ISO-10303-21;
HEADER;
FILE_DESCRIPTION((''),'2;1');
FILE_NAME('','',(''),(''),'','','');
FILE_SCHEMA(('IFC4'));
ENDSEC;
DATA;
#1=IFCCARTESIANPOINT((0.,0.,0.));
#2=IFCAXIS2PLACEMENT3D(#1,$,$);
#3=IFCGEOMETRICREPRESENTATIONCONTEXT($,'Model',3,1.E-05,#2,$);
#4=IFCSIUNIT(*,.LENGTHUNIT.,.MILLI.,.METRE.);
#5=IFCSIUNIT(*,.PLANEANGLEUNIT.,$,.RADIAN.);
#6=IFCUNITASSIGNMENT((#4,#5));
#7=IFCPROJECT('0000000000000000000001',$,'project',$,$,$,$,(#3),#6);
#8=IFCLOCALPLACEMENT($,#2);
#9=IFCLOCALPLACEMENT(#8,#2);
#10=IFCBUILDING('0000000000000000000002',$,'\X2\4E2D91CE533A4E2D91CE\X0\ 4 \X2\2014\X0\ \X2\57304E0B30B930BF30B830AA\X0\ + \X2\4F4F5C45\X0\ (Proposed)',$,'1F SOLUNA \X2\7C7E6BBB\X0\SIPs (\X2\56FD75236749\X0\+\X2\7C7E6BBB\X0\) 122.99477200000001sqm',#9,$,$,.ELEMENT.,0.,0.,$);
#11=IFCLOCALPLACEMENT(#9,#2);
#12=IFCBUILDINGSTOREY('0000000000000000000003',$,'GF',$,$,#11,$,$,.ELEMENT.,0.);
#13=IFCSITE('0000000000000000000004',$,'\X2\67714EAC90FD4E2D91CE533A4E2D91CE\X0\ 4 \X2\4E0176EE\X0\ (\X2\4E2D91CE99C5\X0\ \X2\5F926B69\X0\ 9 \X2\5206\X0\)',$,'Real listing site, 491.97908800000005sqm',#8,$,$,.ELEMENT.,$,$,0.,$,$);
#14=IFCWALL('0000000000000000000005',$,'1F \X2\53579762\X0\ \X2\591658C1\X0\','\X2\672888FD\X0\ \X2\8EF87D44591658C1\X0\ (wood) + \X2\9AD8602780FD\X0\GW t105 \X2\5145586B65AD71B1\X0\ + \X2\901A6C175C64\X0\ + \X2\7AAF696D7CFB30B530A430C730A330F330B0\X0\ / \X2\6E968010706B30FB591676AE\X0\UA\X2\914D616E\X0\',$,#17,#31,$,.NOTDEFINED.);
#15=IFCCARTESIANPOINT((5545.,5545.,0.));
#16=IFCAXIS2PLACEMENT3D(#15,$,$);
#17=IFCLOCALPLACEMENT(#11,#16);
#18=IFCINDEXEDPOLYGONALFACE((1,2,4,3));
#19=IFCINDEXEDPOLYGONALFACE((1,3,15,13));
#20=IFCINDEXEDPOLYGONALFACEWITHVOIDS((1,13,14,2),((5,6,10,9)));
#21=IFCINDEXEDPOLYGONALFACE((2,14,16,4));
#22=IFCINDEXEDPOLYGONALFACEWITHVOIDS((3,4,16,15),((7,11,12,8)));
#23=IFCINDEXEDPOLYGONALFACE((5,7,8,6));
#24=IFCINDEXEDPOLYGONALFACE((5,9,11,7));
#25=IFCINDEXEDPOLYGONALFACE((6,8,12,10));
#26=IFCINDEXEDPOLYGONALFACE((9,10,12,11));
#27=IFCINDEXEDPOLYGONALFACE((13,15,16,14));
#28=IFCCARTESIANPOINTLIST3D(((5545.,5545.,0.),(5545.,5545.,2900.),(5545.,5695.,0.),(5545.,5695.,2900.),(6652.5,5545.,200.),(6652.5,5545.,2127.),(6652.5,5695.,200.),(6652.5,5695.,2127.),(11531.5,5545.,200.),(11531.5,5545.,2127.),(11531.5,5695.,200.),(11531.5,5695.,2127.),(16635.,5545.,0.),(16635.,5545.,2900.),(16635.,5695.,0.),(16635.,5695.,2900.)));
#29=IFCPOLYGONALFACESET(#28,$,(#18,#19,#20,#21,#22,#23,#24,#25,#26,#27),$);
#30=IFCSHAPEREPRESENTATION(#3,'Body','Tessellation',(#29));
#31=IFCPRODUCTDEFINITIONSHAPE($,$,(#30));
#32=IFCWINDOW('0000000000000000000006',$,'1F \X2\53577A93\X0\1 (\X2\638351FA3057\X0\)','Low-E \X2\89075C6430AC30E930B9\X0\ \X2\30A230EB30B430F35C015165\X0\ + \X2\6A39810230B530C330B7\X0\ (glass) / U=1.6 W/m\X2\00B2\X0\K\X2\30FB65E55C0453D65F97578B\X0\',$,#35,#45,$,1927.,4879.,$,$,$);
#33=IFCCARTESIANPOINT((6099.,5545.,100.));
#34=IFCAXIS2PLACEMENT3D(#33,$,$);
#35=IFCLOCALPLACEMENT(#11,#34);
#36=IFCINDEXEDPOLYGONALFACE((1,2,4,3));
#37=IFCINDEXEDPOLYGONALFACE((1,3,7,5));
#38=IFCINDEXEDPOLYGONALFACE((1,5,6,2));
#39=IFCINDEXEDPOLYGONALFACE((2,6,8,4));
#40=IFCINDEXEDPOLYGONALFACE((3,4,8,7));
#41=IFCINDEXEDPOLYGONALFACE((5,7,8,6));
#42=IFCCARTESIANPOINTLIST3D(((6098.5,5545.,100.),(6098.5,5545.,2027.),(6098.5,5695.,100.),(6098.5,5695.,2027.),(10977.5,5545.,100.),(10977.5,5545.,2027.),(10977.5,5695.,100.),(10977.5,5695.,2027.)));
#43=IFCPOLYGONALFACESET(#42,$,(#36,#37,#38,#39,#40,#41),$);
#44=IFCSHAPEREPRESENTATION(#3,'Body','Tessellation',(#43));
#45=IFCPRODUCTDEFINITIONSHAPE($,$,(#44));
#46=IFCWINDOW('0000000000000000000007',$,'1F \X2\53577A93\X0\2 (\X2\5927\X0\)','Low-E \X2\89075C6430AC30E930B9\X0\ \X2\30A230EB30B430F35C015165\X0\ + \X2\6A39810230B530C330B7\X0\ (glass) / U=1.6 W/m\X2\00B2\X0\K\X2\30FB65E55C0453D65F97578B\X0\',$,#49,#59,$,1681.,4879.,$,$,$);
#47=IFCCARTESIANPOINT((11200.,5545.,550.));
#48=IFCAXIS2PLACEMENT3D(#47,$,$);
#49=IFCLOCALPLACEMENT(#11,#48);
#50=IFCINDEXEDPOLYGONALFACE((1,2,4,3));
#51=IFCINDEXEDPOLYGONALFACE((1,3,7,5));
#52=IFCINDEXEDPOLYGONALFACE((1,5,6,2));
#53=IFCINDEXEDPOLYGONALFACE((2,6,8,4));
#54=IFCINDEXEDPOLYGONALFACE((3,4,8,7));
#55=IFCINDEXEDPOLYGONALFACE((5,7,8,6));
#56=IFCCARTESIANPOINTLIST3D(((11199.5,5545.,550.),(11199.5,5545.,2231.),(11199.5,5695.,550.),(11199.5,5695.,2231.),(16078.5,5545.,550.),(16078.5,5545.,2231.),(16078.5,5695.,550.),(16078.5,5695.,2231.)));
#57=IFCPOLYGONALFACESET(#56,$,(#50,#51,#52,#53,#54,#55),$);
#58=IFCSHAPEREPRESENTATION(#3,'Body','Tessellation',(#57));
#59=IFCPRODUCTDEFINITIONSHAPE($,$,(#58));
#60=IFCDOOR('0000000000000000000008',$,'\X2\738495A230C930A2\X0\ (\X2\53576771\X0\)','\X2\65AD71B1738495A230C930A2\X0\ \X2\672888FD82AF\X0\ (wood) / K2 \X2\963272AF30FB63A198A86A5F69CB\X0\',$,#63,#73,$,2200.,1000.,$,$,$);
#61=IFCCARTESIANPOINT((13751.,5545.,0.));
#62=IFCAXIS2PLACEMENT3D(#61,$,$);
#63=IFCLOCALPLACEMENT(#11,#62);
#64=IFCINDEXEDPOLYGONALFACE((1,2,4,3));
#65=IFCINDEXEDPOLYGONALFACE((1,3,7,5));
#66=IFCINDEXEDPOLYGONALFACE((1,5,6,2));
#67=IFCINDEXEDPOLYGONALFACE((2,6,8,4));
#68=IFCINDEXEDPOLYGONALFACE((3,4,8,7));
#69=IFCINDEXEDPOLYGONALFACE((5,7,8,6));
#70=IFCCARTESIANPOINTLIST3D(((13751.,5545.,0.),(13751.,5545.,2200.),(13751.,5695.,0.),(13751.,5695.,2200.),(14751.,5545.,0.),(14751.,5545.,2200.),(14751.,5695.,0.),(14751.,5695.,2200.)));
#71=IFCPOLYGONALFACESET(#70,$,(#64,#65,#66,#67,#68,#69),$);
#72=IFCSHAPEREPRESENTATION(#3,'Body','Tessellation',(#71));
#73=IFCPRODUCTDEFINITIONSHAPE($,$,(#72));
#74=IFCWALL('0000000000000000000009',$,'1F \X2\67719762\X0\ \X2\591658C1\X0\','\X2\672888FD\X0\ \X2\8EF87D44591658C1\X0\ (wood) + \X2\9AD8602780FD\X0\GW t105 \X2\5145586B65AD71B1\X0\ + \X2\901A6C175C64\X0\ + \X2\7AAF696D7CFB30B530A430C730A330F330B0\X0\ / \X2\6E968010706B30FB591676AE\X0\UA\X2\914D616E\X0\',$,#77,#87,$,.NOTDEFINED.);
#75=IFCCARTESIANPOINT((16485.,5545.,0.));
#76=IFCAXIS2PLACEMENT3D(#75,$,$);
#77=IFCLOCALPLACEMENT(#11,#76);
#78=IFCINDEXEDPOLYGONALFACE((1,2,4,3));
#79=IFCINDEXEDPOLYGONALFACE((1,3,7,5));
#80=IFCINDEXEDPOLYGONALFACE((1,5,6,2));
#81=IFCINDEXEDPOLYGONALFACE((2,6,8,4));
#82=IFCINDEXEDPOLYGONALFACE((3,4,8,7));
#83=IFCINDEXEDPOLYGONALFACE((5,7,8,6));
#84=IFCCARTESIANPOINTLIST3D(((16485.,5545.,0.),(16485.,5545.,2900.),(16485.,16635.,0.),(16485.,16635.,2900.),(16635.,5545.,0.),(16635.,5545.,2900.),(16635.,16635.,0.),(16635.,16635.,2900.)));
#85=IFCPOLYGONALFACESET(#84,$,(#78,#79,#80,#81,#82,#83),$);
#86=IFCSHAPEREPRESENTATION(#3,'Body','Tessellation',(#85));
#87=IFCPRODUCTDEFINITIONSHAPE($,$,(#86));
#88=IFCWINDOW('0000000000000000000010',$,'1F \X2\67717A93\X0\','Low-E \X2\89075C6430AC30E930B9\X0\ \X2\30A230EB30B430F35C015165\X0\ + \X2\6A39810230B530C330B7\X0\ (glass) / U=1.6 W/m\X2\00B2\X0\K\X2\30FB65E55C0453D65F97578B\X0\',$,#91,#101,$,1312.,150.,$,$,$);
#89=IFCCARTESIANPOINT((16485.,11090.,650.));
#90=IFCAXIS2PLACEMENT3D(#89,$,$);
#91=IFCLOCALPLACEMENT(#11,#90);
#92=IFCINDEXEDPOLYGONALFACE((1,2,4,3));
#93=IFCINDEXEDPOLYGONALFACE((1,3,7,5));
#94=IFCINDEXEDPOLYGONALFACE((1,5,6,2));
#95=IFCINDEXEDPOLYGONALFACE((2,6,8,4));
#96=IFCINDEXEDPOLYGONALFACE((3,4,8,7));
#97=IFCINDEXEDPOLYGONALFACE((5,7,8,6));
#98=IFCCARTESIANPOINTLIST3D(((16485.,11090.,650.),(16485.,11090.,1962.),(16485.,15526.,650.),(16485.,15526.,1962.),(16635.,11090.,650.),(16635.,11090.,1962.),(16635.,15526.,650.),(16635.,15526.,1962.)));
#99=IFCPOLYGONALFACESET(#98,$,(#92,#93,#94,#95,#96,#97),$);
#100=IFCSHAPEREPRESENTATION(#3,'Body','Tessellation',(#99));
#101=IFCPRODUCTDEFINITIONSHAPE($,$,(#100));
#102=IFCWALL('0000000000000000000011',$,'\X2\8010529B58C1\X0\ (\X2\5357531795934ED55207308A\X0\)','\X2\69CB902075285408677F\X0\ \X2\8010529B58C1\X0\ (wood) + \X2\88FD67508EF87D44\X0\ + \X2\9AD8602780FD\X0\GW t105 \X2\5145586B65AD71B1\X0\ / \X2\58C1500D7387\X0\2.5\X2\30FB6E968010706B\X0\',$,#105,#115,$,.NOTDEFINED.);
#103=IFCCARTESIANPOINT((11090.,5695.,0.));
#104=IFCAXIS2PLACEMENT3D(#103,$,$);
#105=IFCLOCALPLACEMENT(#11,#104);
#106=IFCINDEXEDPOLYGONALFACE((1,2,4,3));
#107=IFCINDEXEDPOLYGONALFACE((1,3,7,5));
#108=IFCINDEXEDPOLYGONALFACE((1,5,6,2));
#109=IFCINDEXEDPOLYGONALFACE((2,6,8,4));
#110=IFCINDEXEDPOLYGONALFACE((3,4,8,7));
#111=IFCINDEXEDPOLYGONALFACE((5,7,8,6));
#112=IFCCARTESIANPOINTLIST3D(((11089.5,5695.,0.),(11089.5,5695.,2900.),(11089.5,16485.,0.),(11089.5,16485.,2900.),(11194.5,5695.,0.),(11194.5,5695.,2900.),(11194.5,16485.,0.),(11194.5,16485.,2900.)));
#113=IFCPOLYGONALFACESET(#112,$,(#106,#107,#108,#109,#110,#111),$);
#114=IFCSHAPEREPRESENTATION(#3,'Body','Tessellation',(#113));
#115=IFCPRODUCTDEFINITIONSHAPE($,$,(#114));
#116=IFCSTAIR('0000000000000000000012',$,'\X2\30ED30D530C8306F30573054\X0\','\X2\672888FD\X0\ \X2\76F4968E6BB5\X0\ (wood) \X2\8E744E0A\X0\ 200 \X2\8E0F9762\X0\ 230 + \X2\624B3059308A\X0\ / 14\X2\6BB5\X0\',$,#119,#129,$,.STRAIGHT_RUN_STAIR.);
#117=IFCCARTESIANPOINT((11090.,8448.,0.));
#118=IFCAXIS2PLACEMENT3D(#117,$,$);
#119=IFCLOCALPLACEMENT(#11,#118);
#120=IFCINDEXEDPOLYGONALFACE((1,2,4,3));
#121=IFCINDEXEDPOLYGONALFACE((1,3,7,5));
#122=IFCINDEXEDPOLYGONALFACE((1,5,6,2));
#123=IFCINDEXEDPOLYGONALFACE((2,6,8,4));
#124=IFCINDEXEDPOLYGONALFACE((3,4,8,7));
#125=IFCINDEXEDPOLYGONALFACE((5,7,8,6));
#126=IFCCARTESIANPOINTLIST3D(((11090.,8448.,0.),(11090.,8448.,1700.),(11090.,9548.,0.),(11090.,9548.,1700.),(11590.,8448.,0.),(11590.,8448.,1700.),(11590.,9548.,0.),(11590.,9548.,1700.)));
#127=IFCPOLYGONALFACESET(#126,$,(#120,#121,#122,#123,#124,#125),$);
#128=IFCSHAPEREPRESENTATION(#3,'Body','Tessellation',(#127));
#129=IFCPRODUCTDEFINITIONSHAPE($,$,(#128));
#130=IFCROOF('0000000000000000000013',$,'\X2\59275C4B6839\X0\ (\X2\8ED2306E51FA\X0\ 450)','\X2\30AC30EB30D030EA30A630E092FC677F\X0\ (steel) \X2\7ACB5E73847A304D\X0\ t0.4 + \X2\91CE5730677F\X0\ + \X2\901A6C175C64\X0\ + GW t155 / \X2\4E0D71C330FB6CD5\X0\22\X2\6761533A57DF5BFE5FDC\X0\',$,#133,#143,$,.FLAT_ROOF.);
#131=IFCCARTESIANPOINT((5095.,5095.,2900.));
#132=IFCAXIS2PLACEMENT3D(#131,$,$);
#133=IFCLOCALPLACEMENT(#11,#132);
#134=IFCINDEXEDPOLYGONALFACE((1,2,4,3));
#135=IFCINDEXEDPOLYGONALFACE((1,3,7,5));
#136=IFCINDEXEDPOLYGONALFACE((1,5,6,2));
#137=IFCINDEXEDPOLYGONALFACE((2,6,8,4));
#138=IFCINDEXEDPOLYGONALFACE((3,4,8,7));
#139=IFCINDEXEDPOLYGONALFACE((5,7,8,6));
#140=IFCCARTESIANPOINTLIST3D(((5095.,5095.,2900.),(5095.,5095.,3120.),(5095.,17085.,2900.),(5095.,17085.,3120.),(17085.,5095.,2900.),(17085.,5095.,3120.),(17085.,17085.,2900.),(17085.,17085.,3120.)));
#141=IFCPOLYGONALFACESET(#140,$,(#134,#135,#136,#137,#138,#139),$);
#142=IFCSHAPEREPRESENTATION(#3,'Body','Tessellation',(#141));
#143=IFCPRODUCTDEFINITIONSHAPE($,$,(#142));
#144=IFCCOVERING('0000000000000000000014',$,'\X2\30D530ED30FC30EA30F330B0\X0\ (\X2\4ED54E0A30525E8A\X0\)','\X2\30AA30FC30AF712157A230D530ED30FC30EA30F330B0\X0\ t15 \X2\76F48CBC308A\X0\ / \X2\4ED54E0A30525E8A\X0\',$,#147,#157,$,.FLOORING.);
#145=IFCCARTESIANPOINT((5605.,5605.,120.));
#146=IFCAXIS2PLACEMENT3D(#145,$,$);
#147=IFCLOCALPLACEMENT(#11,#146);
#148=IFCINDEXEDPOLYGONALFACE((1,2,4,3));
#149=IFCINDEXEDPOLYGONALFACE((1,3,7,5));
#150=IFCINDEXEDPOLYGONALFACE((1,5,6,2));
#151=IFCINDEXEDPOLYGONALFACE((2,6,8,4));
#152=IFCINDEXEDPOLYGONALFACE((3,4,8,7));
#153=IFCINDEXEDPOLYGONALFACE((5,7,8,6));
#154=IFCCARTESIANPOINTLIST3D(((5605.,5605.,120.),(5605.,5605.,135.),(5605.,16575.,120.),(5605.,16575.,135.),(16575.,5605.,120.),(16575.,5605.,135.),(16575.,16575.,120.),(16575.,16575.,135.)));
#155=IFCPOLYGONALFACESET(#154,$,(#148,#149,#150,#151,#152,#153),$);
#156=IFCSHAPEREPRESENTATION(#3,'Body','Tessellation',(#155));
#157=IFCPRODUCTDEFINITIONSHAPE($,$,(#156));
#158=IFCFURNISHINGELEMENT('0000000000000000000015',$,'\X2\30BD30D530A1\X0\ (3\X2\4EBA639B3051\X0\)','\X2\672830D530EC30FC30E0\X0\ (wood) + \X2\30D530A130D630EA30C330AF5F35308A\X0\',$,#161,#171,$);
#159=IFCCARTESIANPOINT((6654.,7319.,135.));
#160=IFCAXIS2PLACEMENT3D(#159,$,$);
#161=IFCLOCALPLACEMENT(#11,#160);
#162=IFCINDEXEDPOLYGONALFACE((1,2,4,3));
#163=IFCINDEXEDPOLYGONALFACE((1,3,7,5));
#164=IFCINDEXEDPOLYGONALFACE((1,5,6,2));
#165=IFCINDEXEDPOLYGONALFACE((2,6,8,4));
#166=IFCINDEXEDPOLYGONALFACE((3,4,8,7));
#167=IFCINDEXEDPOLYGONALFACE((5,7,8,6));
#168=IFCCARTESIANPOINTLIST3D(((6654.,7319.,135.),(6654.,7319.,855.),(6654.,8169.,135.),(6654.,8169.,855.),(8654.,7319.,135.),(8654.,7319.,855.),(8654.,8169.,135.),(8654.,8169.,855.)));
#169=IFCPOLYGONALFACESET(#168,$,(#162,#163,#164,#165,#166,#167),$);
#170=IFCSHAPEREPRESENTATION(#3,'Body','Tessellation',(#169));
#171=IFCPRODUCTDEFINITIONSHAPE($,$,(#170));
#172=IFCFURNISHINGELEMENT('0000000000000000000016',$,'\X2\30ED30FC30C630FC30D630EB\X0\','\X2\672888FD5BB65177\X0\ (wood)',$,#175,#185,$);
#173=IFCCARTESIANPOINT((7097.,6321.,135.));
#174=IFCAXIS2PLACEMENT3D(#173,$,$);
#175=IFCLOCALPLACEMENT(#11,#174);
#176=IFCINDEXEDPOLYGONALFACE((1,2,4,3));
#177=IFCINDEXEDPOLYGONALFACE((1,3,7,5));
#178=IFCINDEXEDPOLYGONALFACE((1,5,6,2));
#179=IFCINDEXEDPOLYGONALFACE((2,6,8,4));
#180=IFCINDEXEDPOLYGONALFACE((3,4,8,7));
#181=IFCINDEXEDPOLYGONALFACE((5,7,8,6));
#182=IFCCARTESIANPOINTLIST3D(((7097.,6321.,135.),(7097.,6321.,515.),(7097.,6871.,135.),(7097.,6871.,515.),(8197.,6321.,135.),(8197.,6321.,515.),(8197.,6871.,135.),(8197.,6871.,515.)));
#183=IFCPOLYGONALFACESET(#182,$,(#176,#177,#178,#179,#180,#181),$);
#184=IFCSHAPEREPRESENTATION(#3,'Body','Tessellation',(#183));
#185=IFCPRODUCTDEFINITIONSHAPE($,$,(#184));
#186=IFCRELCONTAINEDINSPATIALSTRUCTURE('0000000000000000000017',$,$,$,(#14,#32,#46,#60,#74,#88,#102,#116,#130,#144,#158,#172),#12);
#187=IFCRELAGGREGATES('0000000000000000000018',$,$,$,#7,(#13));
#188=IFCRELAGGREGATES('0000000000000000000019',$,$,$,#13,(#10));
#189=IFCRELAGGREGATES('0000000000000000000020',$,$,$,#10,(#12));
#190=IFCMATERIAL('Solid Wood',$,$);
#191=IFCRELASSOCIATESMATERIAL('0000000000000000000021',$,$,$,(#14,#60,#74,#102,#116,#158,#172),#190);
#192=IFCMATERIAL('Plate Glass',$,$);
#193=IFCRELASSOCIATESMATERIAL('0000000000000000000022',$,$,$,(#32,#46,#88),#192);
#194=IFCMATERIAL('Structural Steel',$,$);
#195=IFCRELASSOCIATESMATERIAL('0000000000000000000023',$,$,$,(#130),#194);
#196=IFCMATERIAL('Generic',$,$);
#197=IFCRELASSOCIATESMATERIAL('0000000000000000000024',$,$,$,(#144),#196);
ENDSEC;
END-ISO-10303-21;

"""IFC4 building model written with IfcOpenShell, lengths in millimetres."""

from ifc_helpers import new_model, si_unit, frame, frame_2d, origin, place, context, project, spatial, rectangle, extrude, material, element, fill, save


model = new_model("IFC4")

# Units and contexts
model_context = context("Model", 3, precision=1e-05, world=origin())
ifc_project = project(units=[si_unit("LENGTHUNIT", "METRE", prefix="MILLI"), si_unit("PLANEANGLEUNIT", "RADIAN")], contexts=[model_context])

# Site, building, storey
site_placement = place(None, origin())
site = spatial("IfcSite", under=ifc_project, at=site_placement, Name="東京都中野区中野 4 丁目 (中野駅 徒歩 9 分)", ObjectType="Real listing site, 491.97908800000005sqm", CompositionType="ELEMENT", RefElevation=0.0)
building_placement = place(site_placement, origin())
building = spatial("IfcBuilding", under=site, at=building_placement, Name="中野区中野 4 — 地下スタジオ + 住居 (Proposed)", ObjectType="1F SOLUNA 籾殻SIPs (国産杉+籾殻) 122.99477200000001sqm", CompositionType="ELEMENT", ElevationOfRefHeight=0.0, ElevationOfTerrain=0.0)
storey_placement = place(building_placement, origin())
storey = spatial("IfcBuildingStorey", under=building, at=storey_placement, Name="GF", CompositionType="ELEMENT", Elevation=0.0)

# Shared definitions
ifc_material_1 = material(Name="Solid Wood")

# Wall, openings, windows, door
wall_1_placement = place(storey_placement, frame((5545.0, 5545.0, 0.0)))
wall_1 = element("IfcWall", 1, at=wall_1_placement, inside=storey, material=ifc_material_1, Name="1F 南面 外壁", Description="木製 軸組外壁 (wood) + 高性能GW t105 充填断熱 + 通気層 + 窯業系サイディング / 準耐火・外皮UA配慮", PredefinedType="NOTDEFINED", context=model_context, shape_type="SweptSolid", body=[
    extrude(rectangle(XDim=11090.0, YDim=150.0, at=frame_2d((5545.0, 75.0))), frame((5545.0, 5545.0, 0.0)), (0.0, 0.0, 1.0), 2900.0),
])
opening_1_placement = place(storey_placement, frame((6099.0, 5545.0, 100.0)))
opening_1 = element("IfcOpeningElement", 2, at=opening_1_placement, cuts=wall_1, PredefinedType="NOTDEFINED", context=model_context, shape_type="SweptSolid", body=[
    extrude(rectangle(XDim=4879.0, YDim=150.0, at=frame_2d((2439.0, 75.0))), frame((6099.0, 5545.0, 100.0)), (0.0, 0.0, 1.0), 1927.0),
])
opening_2_placement = place(storey_placement, frame((11200.0, 5545.0, 550.0)))
opening_2 = element("IfcOpeningElement", 3, at=opening_2_placement, cuts=wall_1, PredefinedType="NOTDEFINED", context=model_context, shape_type="SweptSolid", body=[
    extrude(rectangle(XDim=4879.0, YDim=150.0, at=frame_2d((2439.0, 75.0))), frame((11200.0, 5545.0, 550.0)), (0.0, 0.0, 1.0), 1681.0),
])
opening_3_placement = place(storey_placement, frame((13751.0, 5545.0, 0.0)))
opening_3 = element("IfcOpeningElement", 4, at=opening_3_placement, cuts=wall_1, PredefinedType="NOTDEFINED", context=model_context, shape_type="SweptSolid", body=[
    extrude(rectangle(XDim=1000.0, YDim=150.0, at=frame_2d((500.0, 75.0))), frame((13751.0, 5545.0, 0.0)), (0.0, 0.0, 1.0), 2200.0),
])
ifc_material_2 = material(Name="Plate Glass")
window_1_placement = place(storey_placement, frame((6099.0, 5545.0, 100.0)))
window_1 = element("IfcWindow", 5, at=window_1_placement, inside=storey, material=ifc_material_2, Name="1F 南窓1 (掃出し)", Description="Low-E 複層ガラス アルゴン封入 + 樹脂サッシ (glass) / U=1.6 W/m²K・日射取得型", OverallHeight=1927.0, OverallWidth=4879.0, context=model_context, shape_type="SweptSolid", body=[
    extrude(rectangle(XDim=4879.0, YDim=150.0, at=frame_2d((2439.0, 75.0))), frame((6099.0, 5545.0, 100.0)), (0.0, 0.0, 1.0), 1927.0),
])
fill(opening_1, window_1)
window_2_placement = place(storey_placement, frame((11200.0, 5545.0, 550.0)))
window_2 = element("IfcWindow", 6, at=window_2_placement, inside=storey, material=ifc_material_2, Name="1F 南窓2 (大)", Description="Low-E 複層ガラス アルゴン封入 + 樹脂サッシ (glass) / U=1.6 W/m²K・日射取得型", OverallHeight=1681.0, OverallWidth=4879.0, context=model_context, shape_type="SweptSolid", body=[
    extrude(rectangle(XDim=4879.0, YDim=150.0, at=frame_2d((2439.0, 75.0))), frame((11200.0, 5545.0, 550.0)), (0.0, 0.0, 1.0), 1681.0),
])
fill(opening_2, window_2)
door_placement = place(storey_placement, frame((13751.0, 5545.0, 0.0)))
door = element("IfcDoor", 7, at=door_placement, inside=storey, material=ifc_material_1, Name="玄関ドア (南東)", Description="断熱玄関ドア 木製芯 (wood) / K2 防犯・採風機構", OverallHeight=2200.0, OverallWidth=1000.0, context=model_context, shape_type="SweptSolid", body=[
    extrude(rectangle(XDim=1000.0, YDim=150.0, at=frame_2d((500.0, 75.0))), frame((13751.0, 5545.0, 0.0)), (0.0, 0.0, 1.0), 2200.0),
])
fill(opening_3, door)

# Wall, opening, window
wall_2_placement = place(storey_placement, frame((16485.0, 5545.0, 0.0)))
wall_2 = element("IfcWall", 8, at=wall_2_placement, inside=storey, material=ifc_material_1, Name="1F 東面 外壁", Description="木製 軸組外壁 (wood) + 高性能GW t105 充填断熱 + 通気層 + 窯業系サイディング / 準耐火・外皮UA配慮", PredefinedType="NOTDEFINED", context=model_context, shape_type="SweptSolid", body=[
    extrude(rectangle(XDim=150.0, YDim=11090.0, at=frame_2d((75.0, 5545.0))), frame((16485.0, 5545.0, 0.0)), (0.0, 0.0, 1.0), 2900.0),
])
opening_4_placement = place(storey_placement, frame((16485.0, 11090.0, 650.0)))
opening_4 = element("IfcOpeningElement", 9, at=opening_4_placement, cuts=wall_2, PredefinedType="NOTDEFINED", context=model_context, shape_type="SweptSolid", body=[
    extrude(rectangle(XDim=150.0, YDim=4436.0, at=frame_2d((75.0, 2218.0))), frame((16485.0, 11090.0, 650.0)), (0.0, 0.0, 1.0), 1312.0),
])
window_3_placement = place(storey_placement, frame((16485.0, 11090.0, 650.0)))
window_3 = element("IfcWindow", 10, at=window_3_placement, inside=storey, material=ifc_material_2, Name="1F 東窓", Description="Low-E 複層ガラス アルゴン封入 + 樹脂サッシ (glass) / U=1.6 W/m²K・日射取得型", OverallHeight=1312.0, OverallWidth=150.0, context=model_context, shape_type="SweptSolid", body=[
    extrude(rectangle(XDim=150.0, YDim=4436.0, at=frame_2d((75.0, 2218.0))), frame((16485.0, 11090.0, 650.0)), (0.0, 0.0, 1.0), 1312.0),
])
fill(opening_4, window_3)

# Wall
wall_3_placement = place(storey_placement, frame((11090.0, 5695.0, 0.0)))
element("IfcWall", 11, at=wall_3_placement, inside=storey, material=ifc_material_1, Name="耐力壁 (南北間仕切り)", Description="構造用合板 耐力壁 (wood) + 製材軸組 + 高性能GW t105 充填断熱 / 壁倍率2.5・準耐火", PredefinedType="NOTDEFINED", context=model_context, shape_type="SweptSolid", body=[
    extrude(rectangle(XDim=105.0, YDim=10790.0, at=frame_2d((52.0, 5395.0))), frame((11090.0, 5695.0, 0.0)), (0.0, 0.0, 1.0), 2900.0),
])

# Stair
stair_placement = place(storey_placement, frame((11090.0, 8448.0, 0.0)))
element("IfcStair", 12, at=stair_placement, inside=storey, material=ifc_material_1, Name="ロフトはしご", Description="木製 直階段 (wood) 蹴上 200 踏面 230 + 手すり / 14段", PredefinedType="STRAIGHT_RUN_STAIR", context=model_context, shape_type="SweptSolid", body=[
    extrude(rectangle(XDim=500.0, YDim=1100.0, at=frame_2d((250.0, 550.0))), frame((11090.0, 8448.0, 0.0)), (0.0, 0.0, 1.0), 1700.0),
])

# Roof
ifc_material_3 = material(Name="Structural Steel")
roof_placement = place(storey_placement, frame((5095.0, 5095.0, 2900.0)))
element("IfcRoof", 13, at=roof_placement, inside=storey, material=ifc_material_3, Name="大屋根 (軒の出 450)", Description="ガルバリウム鋼板 (steel) 立平葺き t0.4 + 野地板 + 通気層 + GW t155 / 不燃・法22条区域対応", PredefinedType="FLAT_ROOF", context=model_context, shape_type="SweptSolid", body=[
    extrude(rectangle(XDim=11990.0, YDim=11990.0, at=frame_2d((5995.0, 5995.0))), frame((5095.0, 5095.0, 2900.0)), (0.0, 0.0, 1.0), 220.0),
])

# Covering
ifc_material_4 = material(Name="Generic")
covering_placement = place(storey_placement, frame((5605.0, 5605.0, 120.0)))
element("IfcCovering", 14, at=covering_placement, inside=storey, material=ifc_material_4, Name="フローリング (仕上げ床)", Description="オーク無垢フローリング t15 直貼り / 仕上げ床", PredefinedType="FLOORING", context=model_context, shape_type="SweptSolid", body=[
    extrude(rectangle(XDim=10970.0, YDim=10970.0, at=frame_2d((5485.0, 5485.0))), frame((5605.0, 5605.0, 120.0)), (0.0, 0.0, 1.0), 15.0),
])

# Furnishing elements
furnishing_1_placement = place(storey_placement, frame((6654.0, 7319.0, 135.0)))
element("IfcFurnishingElement", 15, at=furnishing_1_placement, inside=storey, material=ifc_material_1, Name="ソファ (3人掛け)", Description="木フレーム (wood) + ファブリック張り", context=model_context, shape_type="SweptSolid", body=[
    extrude(rectangle(XDim=2000.0, YDim=850.0, at=frame_2d((1000.0, 425.0))), frame((6654.0, 7319.0, 135.0)), (0.0, 0.0, 1.0), 720.0),
])
furnishing_2_placement = place(storey_placement, frame((7097.0, 6321.0, 135.0)))
element("IfcFurnishingElement", 16, at=furnishing_2_placement, inside=storey, material=ifc_material_1, Name="ローテーブル", Description="木製家具 (wood)", context=model_context, shape_type="SweptSolid", body=[
    extrude(rectangle(XDim=1100.0, YDim=550.0, at=frame_2d((550.0, 275.0))), frame((7097.0, 6321.0, 135.0)), (0.0, 0.0, 1.0), 380.0),
])

save(model, "model.ifc")
